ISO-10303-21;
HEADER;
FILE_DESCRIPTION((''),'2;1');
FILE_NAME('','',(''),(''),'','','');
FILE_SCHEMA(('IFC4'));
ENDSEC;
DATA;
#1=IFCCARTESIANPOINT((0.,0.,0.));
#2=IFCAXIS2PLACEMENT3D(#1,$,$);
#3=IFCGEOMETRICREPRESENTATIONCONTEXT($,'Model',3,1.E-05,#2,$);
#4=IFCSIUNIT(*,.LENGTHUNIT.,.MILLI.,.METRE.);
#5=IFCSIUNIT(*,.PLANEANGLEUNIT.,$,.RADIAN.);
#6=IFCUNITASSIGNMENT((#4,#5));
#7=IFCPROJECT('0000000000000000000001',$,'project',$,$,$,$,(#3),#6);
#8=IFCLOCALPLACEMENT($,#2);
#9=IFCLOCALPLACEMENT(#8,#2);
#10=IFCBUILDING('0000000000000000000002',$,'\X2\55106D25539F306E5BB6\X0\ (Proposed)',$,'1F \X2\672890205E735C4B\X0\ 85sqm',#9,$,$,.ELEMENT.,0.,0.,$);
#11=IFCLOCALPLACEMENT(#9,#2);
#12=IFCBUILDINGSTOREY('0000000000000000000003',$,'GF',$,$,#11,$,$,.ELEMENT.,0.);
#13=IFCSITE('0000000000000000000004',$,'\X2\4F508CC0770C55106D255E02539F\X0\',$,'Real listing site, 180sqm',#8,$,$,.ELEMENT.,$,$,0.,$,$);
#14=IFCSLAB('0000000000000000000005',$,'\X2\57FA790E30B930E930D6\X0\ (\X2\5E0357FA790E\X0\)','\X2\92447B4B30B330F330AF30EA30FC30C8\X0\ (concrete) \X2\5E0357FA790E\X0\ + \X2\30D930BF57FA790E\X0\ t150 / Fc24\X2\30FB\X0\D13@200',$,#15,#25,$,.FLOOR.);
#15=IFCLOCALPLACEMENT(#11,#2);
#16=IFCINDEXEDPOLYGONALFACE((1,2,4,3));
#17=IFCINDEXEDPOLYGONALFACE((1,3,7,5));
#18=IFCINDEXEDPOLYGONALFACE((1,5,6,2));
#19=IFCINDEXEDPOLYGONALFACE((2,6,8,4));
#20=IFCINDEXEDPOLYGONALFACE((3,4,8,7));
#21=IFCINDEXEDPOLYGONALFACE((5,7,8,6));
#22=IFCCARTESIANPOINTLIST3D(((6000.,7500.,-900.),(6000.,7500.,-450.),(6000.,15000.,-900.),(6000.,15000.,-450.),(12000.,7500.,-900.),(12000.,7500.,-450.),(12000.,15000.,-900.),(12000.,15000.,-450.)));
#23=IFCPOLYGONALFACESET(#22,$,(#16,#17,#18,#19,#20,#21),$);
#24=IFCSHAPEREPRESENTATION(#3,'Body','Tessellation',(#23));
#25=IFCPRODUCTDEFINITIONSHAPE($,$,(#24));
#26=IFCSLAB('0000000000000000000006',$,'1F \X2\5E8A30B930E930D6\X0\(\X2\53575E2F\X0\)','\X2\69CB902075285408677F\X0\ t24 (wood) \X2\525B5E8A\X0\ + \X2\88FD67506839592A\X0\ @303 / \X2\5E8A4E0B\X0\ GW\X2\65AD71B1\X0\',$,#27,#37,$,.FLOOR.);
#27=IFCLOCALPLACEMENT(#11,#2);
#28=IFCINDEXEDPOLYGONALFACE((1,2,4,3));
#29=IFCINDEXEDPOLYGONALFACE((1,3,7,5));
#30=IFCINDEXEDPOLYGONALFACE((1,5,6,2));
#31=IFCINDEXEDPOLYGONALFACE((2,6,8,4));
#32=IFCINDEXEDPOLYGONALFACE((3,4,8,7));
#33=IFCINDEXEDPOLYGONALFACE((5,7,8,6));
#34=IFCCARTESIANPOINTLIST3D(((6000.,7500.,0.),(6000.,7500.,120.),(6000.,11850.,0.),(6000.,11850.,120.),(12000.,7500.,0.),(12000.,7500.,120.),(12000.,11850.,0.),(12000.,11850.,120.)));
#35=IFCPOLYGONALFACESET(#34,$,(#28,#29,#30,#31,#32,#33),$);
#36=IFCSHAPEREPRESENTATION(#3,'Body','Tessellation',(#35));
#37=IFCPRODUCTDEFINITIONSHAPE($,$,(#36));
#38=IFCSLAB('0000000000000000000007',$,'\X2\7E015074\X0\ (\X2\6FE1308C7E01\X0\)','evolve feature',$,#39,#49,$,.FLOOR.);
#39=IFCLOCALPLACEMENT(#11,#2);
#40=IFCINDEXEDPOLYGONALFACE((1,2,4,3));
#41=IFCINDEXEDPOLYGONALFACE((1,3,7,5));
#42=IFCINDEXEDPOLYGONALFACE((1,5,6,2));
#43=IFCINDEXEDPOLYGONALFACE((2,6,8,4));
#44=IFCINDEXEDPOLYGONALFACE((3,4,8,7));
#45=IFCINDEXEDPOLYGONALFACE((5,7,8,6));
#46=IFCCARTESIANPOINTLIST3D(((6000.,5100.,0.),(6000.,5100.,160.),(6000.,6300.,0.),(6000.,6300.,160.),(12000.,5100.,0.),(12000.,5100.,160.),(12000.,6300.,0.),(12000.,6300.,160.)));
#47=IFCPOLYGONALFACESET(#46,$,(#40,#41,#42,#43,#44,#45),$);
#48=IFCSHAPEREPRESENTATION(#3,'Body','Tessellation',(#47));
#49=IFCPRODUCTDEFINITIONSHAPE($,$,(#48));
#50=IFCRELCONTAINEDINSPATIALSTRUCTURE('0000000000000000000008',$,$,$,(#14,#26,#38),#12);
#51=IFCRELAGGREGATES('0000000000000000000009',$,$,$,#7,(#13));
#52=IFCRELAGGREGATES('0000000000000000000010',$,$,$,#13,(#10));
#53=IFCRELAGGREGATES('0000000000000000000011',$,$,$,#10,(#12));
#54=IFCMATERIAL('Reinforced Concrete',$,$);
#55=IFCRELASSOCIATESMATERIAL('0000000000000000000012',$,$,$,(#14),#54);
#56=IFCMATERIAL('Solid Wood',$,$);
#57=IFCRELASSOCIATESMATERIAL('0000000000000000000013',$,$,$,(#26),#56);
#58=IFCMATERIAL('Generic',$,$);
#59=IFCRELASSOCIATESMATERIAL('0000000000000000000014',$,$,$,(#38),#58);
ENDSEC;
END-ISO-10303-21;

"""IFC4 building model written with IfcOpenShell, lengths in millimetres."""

from ifc_helpers import new_model, si_unit, frame, frame_2d, origin, place, context, project, spatial, rectangle, extrude, material, element, save


model = new_model("IFC4")

# Units and contexts
model_context = context("Model", 3, precision=1e-05, world=origin())
ifc_project = project(units=[si_unit("LENGTHUNIT", "METRE", prefix="MILLI"), si_unit("PLANEANGLEUNIT", "RADIAN")], contexts=[model_context])

# Site, building, storey
site_placement = place(None, origin())
site = spatial("IfcSite", under=ifc_project, at=site_placement, Name="佐賀県唐津市原", ObjectType="Real listing site, 180sqm", CompositionType="ELEMENT", RefElevation=0.0)
building_placement = place(site_placement, origin())
building = spatial("IfcBuilding", under=site, at=building_placement, Name="唐津原の家 (Proposed)", ObjectType="1F 木造平屋 85sqm", CompositionType="ELEMENT", ElevationOfRefHeight=0.0, ElevationOfTerrain=0.0)
storey_placement = place(building_placement, origin())
storey = spatial("IfcBuildingStorey", under=building, at=storey_placement, Name="GF", CompositionType="ELEMENT", Elevation=0.0)

# Slabs
ifc_material_1 = material(Name="Reinforced Concrete")
slab_1_placement = place(storey_placement, frame((3000.0, 3750.0, -450.0)))
element("IfcSlab", 1, at=slab_1_placement, inside=storey, material=ifc_material_1, Name="基礎スラブ (布基礎)", Description="鉄筋コンクリート (concrete) 布基礎 + ベタ基礎 t150 / Fc24・D13@200", PredefinedType="FLOOR", context=model_context, shape_type="SweptSolid", body=[
    extrude(rectangle(XDim=6000.0, YDim=7500.0, at=frame_2d((3000.0, 3750.0))), frame((3000.0, 3750.0, -450.0)), (0.0, 0.0, 1.0), 450.0),
])
ifc_material_2 = material(Name="Solid Wood")
slab_2_placement = place(storey_placement, frame((3000.0, 3750.0, 0.0)))
element("IfcSlab", 2, at=slab_2_placement, inside=storey, material=ifc_material_2, Name="1F 床スラブ(南帯)", Description="構造用合板 t24 (wood) 剛床 + 製材根太 @303 / 床下 GW断熱", PredefinedType="FLOOR", context=model_context, shape_type="SweptSolid", body=[
    extrude(rectangle(XDim=6000.0, YDim=4350.0, at=frame_2d((3000.0, 2175.0))), frame((3000.0, 3750.0, 0.0)), (0.0, 0.0, 1.0), 120.0),
])
ifc_material_3 = material(Name="Generic")
slab_3_placement = place(storey_placement, frame((3000.0, 2550.0, 0.0)))
element("IfcSlab", 3, at=slab_3_placement, inside=storey, material=ifc_material_3, Name="縁側 (濡れ縁)", Description="evolve feature", PredefinedType="FLOOR", context=model_context, shape_type="SweptSolid", body=[
    extrude(rectangle(XDim=6000.0, YDim=1200.0, at=frame_2d((3000.0, 600.0))), frame((3000.0, 2550.0, 0.0)), (0.0, 0.0, 1.0), 160.0),
])

save(model, "model.ifc")
